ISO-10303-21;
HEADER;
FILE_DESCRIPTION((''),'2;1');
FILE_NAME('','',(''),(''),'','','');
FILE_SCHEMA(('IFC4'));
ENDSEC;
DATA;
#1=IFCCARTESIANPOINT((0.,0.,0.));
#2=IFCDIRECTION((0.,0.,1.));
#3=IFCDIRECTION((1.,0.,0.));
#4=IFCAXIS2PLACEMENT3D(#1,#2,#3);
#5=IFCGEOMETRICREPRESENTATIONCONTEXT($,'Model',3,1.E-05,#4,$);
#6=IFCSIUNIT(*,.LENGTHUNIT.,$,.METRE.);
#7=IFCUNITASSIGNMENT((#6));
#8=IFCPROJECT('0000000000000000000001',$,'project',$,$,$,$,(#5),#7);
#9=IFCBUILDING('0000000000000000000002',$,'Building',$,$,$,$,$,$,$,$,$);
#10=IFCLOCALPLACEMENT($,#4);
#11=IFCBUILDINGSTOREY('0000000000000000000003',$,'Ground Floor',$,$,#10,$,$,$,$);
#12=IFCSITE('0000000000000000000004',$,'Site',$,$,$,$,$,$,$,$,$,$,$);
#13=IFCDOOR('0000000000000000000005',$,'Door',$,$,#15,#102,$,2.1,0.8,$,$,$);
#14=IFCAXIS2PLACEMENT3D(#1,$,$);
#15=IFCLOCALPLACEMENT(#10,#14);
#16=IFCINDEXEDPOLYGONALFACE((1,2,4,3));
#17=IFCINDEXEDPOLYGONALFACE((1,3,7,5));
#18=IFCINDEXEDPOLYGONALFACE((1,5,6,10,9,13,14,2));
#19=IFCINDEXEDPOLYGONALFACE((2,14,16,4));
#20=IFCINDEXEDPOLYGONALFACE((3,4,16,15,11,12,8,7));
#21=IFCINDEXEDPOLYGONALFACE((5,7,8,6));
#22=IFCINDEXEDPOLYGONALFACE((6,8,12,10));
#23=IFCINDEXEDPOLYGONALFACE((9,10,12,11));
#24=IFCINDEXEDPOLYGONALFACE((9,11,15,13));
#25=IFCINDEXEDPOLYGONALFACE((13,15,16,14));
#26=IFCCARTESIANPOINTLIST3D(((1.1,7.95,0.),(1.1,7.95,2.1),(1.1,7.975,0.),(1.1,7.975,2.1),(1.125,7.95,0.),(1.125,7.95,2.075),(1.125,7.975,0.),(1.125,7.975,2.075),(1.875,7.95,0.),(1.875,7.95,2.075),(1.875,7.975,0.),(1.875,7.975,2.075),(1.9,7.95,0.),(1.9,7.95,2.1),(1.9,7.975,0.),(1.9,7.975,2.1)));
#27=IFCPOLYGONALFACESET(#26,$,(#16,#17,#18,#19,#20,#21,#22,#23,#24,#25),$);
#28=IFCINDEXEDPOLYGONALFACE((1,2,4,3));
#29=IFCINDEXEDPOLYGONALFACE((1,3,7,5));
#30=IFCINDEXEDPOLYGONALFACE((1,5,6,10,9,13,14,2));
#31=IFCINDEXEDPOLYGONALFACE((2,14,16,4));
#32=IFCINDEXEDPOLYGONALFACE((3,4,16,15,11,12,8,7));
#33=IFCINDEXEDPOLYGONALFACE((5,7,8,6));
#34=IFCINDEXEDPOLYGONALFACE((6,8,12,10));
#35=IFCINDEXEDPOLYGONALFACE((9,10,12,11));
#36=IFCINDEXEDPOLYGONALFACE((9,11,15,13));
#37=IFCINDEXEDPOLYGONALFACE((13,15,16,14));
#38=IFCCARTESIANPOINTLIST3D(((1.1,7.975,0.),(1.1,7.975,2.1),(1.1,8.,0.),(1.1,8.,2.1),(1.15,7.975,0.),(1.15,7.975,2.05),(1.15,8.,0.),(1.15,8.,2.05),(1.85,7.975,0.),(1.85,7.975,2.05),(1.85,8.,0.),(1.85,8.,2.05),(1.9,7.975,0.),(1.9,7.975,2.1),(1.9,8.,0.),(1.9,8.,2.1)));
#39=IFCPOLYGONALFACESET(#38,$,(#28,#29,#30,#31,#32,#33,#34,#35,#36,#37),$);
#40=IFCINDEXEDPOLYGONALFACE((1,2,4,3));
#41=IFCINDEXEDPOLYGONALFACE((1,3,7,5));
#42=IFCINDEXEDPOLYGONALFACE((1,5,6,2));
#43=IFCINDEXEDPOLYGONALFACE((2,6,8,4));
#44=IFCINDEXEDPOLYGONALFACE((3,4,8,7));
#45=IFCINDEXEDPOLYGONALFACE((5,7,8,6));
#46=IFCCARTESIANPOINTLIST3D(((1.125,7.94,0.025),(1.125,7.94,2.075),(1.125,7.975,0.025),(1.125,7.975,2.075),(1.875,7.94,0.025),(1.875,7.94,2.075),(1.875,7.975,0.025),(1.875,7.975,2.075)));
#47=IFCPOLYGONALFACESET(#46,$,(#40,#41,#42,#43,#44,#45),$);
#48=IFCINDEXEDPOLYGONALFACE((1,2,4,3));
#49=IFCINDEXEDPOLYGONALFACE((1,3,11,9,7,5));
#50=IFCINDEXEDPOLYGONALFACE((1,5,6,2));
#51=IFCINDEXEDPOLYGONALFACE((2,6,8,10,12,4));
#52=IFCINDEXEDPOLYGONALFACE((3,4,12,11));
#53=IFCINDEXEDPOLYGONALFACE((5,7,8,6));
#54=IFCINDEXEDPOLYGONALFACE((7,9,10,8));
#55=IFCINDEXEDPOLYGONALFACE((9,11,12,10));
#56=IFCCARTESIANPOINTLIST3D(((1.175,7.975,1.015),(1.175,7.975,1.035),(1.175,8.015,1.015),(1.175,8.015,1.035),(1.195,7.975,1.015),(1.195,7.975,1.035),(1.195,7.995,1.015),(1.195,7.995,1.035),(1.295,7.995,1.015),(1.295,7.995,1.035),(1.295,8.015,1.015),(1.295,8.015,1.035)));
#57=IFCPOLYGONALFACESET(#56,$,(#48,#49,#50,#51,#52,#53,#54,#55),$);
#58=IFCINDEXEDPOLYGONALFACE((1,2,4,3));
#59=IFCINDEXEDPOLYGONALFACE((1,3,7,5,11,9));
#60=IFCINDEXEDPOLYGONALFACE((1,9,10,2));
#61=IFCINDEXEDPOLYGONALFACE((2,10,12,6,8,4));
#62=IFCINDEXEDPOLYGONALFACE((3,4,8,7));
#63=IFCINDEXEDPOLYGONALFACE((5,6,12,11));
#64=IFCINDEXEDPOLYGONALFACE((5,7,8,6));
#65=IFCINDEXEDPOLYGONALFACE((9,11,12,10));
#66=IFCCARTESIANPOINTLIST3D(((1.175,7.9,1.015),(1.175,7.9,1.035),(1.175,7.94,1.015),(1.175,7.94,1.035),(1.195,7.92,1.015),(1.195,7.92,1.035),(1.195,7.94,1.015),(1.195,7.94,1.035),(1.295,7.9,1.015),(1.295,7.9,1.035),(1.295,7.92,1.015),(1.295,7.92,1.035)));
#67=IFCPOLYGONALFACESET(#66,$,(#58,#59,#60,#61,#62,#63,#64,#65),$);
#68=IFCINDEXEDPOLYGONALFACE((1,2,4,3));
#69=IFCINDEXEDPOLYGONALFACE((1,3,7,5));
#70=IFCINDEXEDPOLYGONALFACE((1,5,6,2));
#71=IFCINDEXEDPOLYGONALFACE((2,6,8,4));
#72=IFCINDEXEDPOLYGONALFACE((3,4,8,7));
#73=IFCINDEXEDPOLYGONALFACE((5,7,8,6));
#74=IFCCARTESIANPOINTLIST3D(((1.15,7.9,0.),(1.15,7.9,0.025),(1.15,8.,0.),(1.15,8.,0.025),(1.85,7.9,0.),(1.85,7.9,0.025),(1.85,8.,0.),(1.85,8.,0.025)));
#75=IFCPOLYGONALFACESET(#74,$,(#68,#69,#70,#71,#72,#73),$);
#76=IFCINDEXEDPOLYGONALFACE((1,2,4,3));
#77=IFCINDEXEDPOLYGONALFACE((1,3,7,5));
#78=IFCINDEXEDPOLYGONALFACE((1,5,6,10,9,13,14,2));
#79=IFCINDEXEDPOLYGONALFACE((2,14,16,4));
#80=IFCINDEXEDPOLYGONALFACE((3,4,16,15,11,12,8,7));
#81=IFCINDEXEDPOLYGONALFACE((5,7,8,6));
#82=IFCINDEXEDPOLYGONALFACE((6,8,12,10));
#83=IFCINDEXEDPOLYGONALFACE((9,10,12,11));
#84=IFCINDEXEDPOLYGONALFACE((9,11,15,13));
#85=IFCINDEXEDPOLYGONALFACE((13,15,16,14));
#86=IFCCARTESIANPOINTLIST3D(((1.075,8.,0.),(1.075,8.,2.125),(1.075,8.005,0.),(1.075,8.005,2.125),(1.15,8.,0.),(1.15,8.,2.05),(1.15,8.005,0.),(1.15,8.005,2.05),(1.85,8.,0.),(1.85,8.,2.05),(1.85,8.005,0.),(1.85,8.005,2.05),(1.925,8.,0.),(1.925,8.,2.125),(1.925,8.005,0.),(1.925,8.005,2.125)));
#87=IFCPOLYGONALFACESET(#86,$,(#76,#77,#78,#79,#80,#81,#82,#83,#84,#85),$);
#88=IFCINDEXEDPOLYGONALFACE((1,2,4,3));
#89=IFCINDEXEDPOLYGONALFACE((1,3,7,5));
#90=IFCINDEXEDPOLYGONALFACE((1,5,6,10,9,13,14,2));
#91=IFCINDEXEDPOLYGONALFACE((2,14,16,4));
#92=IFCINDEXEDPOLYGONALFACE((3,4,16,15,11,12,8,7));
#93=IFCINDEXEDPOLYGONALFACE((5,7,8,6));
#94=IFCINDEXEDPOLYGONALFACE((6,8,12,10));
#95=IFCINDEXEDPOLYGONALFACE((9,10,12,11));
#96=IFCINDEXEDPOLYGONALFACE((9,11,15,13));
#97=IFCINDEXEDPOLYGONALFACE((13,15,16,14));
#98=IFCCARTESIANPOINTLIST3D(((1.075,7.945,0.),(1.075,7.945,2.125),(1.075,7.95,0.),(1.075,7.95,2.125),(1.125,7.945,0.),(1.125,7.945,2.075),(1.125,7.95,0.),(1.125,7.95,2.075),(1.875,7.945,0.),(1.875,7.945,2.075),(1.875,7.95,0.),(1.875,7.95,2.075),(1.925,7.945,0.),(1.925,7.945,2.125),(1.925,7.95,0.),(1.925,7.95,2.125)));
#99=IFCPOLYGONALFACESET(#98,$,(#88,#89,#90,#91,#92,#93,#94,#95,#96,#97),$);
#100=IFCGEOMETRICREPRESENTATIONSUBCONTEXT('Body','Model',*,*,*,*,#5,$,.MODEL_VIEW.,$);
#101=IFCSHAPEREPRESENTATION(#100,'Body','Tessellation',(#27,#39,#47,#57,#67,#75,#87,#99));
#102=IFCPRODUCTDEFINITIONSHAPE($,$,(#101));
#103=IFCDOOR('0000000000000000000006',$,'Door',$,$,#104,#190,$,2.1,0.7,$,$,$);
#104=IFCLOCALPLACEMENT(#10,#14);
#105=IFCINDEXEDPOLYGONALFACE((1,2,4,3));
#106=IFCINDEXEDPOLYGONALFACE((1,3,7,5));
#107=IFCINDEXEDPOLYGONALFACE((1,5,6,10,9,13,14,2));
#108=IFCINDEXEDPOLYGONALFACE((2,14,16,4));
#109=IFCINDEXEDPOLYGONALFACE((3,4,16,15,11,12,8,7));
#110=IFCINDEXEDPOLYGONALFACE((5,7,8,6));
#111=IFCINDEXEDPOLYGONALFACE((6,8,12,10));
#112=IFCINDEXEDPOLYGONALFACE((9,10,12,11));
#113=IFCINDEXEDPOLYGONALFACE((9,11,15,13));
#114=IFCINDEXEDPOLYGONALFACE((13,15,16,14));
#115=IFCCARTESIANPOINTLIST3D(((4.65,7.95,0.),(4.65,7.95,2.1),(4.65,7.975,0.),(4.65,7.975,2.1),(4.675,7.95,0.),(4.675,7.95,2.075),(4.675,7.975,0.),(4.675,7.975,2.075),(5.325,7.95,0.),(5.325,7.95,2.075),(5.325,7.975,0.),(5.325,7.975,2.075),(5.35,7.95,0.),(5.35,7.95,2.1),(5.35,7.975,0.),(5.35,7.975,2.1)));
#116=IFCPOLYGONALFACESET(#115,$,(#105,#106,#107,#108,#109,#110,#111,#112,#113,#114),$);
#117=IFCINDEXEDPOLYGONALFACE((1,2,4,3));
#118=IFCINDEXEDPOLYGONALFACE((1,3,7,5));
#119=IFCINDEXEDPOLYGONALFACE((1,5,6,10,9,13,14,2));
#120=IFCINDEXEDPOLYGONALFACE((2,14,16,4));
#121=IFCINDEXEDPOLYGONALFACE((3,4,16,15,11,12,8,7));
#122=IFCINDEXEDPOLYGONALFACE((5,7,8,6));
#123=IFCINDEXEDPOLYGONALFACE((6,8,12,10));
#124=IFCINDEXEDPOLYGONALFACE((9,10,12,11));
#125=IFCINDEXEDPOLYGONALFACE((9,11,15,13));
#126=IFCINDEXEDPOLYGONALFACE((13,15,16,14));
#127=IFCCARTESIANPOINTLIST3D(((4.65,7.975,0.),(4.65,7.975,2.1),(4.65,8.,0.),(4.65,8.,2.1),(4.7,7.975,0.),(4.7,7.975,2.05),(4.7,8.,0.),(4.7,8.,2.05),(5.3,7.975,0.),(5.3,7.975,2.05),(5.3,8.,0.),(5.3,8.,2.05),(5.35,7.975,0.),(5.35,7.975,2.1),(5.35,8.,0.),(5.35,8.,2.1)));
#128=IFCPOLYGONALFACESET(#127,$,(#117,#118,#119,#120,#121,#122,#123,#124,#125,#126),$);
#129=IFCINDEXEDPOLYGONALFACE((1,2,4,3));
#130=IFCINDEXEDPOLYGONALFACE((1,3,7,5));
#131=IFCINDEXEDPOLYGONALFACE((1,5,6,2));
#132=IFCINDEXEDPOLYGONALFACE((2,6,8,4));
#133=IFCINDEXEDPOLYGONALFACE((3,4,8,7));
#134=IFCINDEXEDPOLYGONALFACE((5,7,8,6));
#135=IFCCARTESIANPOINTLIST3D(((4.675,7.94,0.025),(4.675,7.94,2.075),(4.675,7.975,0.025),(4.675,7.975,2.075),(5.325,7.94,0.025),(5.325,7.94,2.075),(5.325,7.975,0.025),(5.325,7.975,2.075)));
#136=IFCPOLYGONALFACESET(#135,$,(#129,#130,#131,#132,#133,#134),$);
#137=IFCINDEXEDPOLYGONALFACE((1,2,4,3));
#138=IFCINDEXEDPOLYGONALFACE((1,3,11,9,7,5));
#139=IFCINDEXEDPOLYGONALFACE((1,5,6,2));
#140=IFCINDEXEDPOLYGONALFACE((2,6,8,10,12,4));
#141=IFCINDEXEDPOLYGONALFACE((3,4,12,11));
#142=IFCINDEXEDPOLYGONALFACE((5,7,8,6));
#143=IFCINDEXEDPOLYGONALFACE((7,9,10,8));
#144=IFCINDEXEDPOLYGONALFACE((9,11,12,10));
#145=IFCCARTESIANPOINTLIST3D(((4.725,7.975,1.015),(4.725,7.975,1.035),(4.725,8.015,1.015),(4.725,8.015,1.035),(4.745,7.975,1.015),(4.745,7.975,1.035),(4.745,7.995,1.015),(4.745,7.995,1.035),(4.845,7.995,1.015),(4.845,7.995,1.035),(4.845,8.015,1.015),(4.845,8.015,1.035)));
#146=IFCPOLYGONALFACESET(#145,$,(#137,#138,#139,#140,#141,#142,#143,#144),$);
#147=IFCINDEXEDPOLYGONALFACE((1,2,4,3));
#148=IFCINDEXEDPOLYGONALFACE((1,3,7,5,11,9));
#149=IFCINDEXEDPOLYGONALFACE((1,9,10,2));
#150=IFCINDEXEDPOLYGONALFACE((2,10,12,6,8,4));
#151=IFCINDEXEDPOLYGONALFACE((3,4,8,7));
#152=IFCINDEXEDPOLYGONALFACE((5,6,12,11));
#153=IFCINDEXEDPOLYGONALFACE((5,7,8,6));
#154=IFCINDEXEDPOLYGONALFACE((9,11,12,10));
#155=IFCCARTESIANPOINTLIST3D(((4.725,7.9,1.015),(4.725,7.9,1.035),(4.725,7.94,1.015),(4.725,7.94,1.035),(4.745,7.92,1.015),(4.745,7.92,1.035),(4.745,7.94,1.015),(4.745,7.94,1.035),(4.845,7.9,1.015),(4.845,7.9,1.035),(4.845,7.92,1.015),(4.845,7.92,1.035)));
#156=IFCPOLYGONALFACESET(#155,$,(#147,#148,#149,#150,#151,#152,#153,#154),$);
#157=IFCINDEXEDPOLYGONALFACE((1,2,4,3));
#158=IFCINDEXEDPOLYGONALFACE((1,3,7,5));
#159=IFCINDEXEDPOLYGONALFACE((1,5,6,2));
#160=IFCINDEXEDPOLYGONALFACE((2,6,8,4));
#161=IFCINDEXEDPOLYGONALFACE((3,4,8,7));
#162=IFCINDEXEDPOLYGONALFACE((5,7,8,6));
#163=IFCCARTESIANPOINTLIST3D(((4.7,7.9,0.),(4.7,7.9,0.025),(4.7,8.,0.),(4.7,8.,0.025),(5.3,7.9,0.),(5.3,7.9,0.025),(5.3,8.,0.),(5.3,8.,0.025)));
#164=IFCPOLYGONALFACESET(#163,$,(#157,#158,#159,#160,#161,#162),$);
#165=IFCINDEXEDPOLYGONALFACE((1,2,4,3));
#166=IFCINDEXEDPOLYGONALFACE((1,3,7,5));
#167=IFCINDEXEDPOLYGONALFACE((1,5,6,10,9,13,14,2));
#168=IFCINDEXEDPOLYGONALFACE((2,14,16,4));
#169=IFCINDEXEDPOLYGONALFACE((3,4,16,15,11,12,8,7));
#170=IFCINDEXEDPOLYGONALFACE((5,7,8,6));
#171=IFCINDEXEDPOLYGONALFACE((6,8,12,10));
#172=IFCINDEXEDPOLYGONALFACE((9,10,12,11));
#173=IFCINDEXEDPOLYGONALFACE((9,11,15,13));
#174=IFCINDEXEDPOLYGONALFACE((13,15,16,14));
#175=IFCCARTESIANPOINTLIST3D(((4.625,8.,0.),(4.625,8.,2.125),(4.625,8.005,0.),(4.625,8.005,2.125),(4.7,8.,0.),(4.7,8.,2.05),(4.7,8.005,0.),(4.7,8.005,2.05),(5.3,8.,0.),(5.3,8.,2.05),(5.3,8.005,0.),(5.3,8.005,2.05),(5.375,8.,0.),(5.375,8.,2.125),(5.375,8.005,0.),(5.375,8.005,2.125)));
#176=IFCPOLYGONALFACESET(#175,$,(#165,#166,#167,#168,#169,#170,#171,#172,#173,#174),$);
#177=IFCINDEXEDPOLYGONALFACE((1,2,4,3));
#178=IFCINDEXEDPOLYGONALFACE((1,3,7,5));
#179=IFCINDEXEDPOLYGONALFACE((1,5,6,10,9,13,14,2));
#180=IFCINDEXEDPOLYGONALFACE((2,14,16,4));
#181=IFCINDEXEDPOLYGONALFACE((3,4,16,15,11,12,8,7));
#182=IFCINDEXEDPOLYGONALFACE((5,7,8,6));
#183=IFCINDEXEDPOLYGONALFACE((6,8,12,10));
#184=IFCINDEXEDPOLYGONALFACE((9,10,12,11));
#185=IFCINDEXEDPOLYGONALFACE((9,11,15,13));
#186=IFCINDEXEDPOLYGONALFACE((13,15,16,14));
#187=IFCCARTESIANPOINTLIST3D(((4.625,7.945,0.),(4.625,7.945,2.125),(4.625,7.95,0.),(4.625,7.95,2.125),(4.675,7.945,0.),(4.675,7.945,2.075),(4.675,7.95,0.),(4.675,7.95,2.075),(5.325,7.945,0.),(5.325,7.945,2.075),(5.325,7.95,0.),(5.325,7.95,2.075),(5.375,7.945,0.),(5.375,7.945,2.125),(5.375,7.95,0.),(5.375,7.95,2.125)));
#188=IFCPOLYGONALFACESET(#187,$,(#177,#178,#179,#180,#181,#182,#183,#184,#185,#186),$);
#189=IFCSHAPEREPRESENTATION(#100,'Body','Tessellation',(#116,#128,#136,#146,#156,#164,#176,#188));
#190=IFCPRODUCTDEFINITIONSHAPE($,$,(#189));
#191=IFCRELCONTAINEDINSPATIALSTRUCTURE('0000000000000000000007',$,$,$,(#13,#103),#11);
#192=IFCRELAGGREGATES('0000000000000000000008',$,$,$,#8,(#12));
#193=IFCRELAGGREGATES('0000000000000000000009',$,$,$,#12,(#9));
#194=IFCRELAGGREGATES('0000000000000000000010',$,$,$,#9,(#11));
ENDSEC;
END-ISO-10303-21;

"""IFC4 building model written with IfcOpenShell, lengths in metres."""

from ifc_helpers import new_model, si_unit, frame, origin_with_axes, place, context, subcontext, project, spatial, line, indexed_curve, outline, extrude, element, save


model = new_model("IFC4")

# Units and contexts
model_context = context("Model", 3, precision=1e-05, world=origin_with_axes())
body_context = subcontext(model_context, "Body", "Model", "MODEL_VIEW")
ifc_project = project(units=[si_unit("LENGTHUNIT", "METRE")], contexts=[model_context])

# Site, building, storey
site = spatial("IfcSite", under=ifc_project, Name="Site")
building = spatial("IfcBuilding", under=site, Name="Building")
storey_placement = place(None, origin_with_axes())
storey = spatial("IfcBuildingStorey", under=building, at=storey_placement, Name="Ground Floor")

# Doors
door_1_placement = place(storey_placement, frame((1.9, 8.0, 0.0), z_axis=(0.0, 0.0, 1.0), x_axis=(-1.0, 0.0, 0.0)))
element("IfcDoor", 1, at=door_1_placement, inside=storey, Name="Door", OverallHeight=2.1, OverallWidth=0.8, context=body_context, shape_type="SweptSolid", body=[
    extrude(outline(indexed_curve([(0.0, 0.0), (0.0, 2.1), (0.8, 2.1), (0.8, 0.0), (0.775, 0.0), (0.775, 2.075), (0.025, 2.075), (0.025, 0.0)], segments=[line(1, 2, 3, 4, 5, 6, 7, 8, 1)])), frame((0.0, 0.025, 0.0), z_axis=(0.0, -1.0, 0.0), x_axis=(1.0, 0.0, 0.0)), (0.0, 0.0, -1.0), 0.025),
    extrude(outline(indexed_curve([(0.0, 0.0), (0.0, 2.1), (0.8, 2.1), (0.8, 0.0), (0.75, 0.0), (0.75, 2.05), (0.05, 2.05), (0.05, 0.0)], segments=[line(1, 2, 3, 4, 5, 6, 7, 8, 1)])), frame((0.0, 0.0, 0.0), z_axis=(0.0, -1.0, 0.0), x_axis=(1.0, 0.0, 0.0)), (0.0, 0.0, -1.0), 0.025),
    extrude(outline(indexed_curve([(0.0, 0.0), (0.75, 0.0), (0.75, 0.035), (0.0, 0.035)], segments=[line(1, 2, 3, 4, 1)])), frame((0.025, 0.025, 0.025), z_axis=(0.0, 0.0, 1.0), x_axis=(1.0, 0.0, 0.0)), (0.0, 0.0, 1.0), 2.05),
    extrude(outline(indexed_curve([(0.0, 0.0), (0.0, -0.04), (-0.12, -0.04), (-0.12, -0.02), (-0.02, -0.02), (-0.02, 0.0)], segments=[line(1, 2, 3, 4, 5, 6, 1)])), frame((0.725, 0.025, 1.015), z_axis=(0.0, 0.0, 1.0), x_axis=(1.0, 0.0, 0.0)), (0.0, 0.0, 1.0), 0.02),
    extrude(outline(indexed_curve([(0.0, 0.0), (0.0, 0.04), (-0.12, 0.04), (-0.12, 0.02), (-0.02, 0.02), (-0.02, 0.0)], segments=[line(1, 2, 3, 4, 5, 6, 1)])), frame((0.725, 0.06, 1.015), z_axis=(0.0, 0.0, 1.0), x_axis=(1.0, 0.0, 0.0)), (0.0, 0.0, 1.0), 0.02),
    extrude(outline(indexed_curve([(0.0, 0.0), (0.7, 0.0), (0.7, 0.1), (0.0, 0.1)], segments=[line(1, 2, 3, 4, 1)])), frame((0.05, 0.0, 0.0), z_axis=(0.0, 0.0, 1.0), x_axis=(1.0, 0.0, 0.0)), (0.0, 0.0, 1.0), 0.025),
    extrude(outline(indexed_curve([(0.0, 0.0), (0.0, 2.125), (0.85, 2.125), (0.85, 0.0), (0.775, 0.0), (0.775, 2.05), (0.075, 2.05), (0.075, 0.0)], segments=[line(1, 2, 3, 4, 5, 6, 7, 8, 1)])), frame((-0.025, -0.005, 0.0), z_axis=(0.0, -1.0, 0.0), x_axis=(1.0, 0.0, 0.0)), (0.0, 0.0, -1.0), 0.005),
    extrude(outline(indexed_curve([(0.0, 0.0), (0.0, 2.125), (0.85, 2.125), (0.85, 0.0), (0.8, 0.0), (0.8, 2.075), (0.05, 2.075), (0.05, 0.0)], segments=[line(1, 2, 3, 4, 5, 6, 7, 8, 1)])), frame((-0.025, 0.05, 0.0), z_axis=(0.0, -1.0, 0.0), x_axis=(1.0, 0.0, 0.0)), (0.0, 0.0, -1.0), 0.005),
])
door_2_placement = place(storey_placement, frame((5.35, 8.0, 0.0), z_axis=(0.0, 0.0, 1.0), x_axis=(-1.0, 0.0, 0.0)))
element("IfcDoor", 2, at=door_2_placement, inside=storey, Name="Door", OverallHeight=2.1, OverallWidth=0.7, context=body_context, shape_type="SweptSolid", body=[
    extrude(outline(indexed_curve([(0.0, 0.0), (0.0, 2.1), (0.7, 2.1), (0.7, 0.0), (0.675, 0.0), (0.675, 2.075), (0.025, 2.075), (0.025, 0.0)], segments=[line(1, 2, 3, 4, 5, 6, 7, 8, 1)])), frame((0.0, 0.025, 0.0), z_axis=(0.0, -1.0, 0.0), x_axis=(1.0, 0.0, 0.0)), (0.0, 0.0, -1.0), 0.025),
    extrude(outline(indexed_curve([(0.0, 0.0), (0.0, 2.1), (0.7, 2.1), (0.7, 0.0), (0.65, 0.0), (0.65, 2.05), (0.05, 2.05), (0.05, 0.0)], segments=[line(1, 2, 3, 4, 5, 6, 7, 8, 1)])), frame((0.0, 0.0, 0.0), z_axis=(0.0, -1.0, 0.0), x_axis=(1.0, 0.0, 0.0)), (0.0, 0.0, -1.0), 0.025),
    extrude(outline(indexed_curve([(0.0, 0.0), (0.65, 0.0), (0.65, 0.035), (0.0, 0.035)], segments=[line(1, 2, 3, 4, 1)])), frame((0.025, 0.025, 0.025), z_axis=(0.0, 0.0, 1.0), x_axis=(1.0, 0.0, 0.0)), (0.0, 0.0, 1.0), 2.05),
    extrude(outline(indexed_curve([(0.0, 0.0), (0.0, -0.04), (-0.12, -0.04), (-0.12, -0.02), (-0.02, -0.02), (-0.02, 0.0)], segments=[line(1, 2, 3, 4, 5, 6, 1)])), frame((0.625, 0.025, 1.015), z_axis=(0.0, 0.0, 1.0), x_axis=(1.0, 0.0, 0.0)), (0.0, 0.0, 1.0), 0.02),
    extrude(outline(indexed_curve([(0.0, 0.0), (0.0, 0.04), (-0.12, 0.04), (-0.12, 0.02), (-0.02, 0.02), (-0.02, 0.0)], segments=[line(1, 2, 3, 4, 5, 6, 1)])), frame((0.625, 0.06, 1.015), z_axis=(0.0, 0.0, 1.0), x_axis=(1.0, 0.0, 0.0)), (0.0, 0.0, 1.0), 0.02),
    extrude(outline(indexed_curve([(0.0, 0.0), (0.6, 0.0), (0.6, 0.1), (0.0, 0.1)], segments=[line(1, 2, 3, 4, 1)])), frame((0.05, 0.0, 0.0), z_axis=(0.0, 0.0, 1.0), x_axis=(1.0, 0.0, 0.0)), (0.0, 0.0, 1.0), 0.025),
    extrude(outline(indexed_curve([(0.0, 0.0), (0.0, 2.125), (0.75, 2.125), (0.75, 0.0), (0.675, 0.0), (0.675, 2.05), (0.075, 2.05), (0.075, 0.0)], segments=[line(1, 2, 3, 4, 5, 6, 7, 8, 1)])), frame((-0.025, -0.005, 0.0), z_axis=(0.0, -1.0, 0.0), x_axis=(1.0, 0.0, 0.0)), (0.0, 0.0, -1.0), 0.005),
    extrude(outline(indexed_curve([(0.0, 0.0), (0.0, 2.125), (0.75, 2.125), (0.75, 0.0), (0.7, 0.0), (0.7, 2.075), (0.05, 2.075), (0.05, 0.0)], segments=[line(1, 2, 3, 4, 5, 6, 7, 8, 1)])), frame((-0.025, 0.05, 0.0), z_axis=(0.0, -1.0, 0.0), x_axis=(1.0, 0.0, 0.0)), (0.0, 0.0, -1.0), 0.005),
])

save(model, "model.ifc")
